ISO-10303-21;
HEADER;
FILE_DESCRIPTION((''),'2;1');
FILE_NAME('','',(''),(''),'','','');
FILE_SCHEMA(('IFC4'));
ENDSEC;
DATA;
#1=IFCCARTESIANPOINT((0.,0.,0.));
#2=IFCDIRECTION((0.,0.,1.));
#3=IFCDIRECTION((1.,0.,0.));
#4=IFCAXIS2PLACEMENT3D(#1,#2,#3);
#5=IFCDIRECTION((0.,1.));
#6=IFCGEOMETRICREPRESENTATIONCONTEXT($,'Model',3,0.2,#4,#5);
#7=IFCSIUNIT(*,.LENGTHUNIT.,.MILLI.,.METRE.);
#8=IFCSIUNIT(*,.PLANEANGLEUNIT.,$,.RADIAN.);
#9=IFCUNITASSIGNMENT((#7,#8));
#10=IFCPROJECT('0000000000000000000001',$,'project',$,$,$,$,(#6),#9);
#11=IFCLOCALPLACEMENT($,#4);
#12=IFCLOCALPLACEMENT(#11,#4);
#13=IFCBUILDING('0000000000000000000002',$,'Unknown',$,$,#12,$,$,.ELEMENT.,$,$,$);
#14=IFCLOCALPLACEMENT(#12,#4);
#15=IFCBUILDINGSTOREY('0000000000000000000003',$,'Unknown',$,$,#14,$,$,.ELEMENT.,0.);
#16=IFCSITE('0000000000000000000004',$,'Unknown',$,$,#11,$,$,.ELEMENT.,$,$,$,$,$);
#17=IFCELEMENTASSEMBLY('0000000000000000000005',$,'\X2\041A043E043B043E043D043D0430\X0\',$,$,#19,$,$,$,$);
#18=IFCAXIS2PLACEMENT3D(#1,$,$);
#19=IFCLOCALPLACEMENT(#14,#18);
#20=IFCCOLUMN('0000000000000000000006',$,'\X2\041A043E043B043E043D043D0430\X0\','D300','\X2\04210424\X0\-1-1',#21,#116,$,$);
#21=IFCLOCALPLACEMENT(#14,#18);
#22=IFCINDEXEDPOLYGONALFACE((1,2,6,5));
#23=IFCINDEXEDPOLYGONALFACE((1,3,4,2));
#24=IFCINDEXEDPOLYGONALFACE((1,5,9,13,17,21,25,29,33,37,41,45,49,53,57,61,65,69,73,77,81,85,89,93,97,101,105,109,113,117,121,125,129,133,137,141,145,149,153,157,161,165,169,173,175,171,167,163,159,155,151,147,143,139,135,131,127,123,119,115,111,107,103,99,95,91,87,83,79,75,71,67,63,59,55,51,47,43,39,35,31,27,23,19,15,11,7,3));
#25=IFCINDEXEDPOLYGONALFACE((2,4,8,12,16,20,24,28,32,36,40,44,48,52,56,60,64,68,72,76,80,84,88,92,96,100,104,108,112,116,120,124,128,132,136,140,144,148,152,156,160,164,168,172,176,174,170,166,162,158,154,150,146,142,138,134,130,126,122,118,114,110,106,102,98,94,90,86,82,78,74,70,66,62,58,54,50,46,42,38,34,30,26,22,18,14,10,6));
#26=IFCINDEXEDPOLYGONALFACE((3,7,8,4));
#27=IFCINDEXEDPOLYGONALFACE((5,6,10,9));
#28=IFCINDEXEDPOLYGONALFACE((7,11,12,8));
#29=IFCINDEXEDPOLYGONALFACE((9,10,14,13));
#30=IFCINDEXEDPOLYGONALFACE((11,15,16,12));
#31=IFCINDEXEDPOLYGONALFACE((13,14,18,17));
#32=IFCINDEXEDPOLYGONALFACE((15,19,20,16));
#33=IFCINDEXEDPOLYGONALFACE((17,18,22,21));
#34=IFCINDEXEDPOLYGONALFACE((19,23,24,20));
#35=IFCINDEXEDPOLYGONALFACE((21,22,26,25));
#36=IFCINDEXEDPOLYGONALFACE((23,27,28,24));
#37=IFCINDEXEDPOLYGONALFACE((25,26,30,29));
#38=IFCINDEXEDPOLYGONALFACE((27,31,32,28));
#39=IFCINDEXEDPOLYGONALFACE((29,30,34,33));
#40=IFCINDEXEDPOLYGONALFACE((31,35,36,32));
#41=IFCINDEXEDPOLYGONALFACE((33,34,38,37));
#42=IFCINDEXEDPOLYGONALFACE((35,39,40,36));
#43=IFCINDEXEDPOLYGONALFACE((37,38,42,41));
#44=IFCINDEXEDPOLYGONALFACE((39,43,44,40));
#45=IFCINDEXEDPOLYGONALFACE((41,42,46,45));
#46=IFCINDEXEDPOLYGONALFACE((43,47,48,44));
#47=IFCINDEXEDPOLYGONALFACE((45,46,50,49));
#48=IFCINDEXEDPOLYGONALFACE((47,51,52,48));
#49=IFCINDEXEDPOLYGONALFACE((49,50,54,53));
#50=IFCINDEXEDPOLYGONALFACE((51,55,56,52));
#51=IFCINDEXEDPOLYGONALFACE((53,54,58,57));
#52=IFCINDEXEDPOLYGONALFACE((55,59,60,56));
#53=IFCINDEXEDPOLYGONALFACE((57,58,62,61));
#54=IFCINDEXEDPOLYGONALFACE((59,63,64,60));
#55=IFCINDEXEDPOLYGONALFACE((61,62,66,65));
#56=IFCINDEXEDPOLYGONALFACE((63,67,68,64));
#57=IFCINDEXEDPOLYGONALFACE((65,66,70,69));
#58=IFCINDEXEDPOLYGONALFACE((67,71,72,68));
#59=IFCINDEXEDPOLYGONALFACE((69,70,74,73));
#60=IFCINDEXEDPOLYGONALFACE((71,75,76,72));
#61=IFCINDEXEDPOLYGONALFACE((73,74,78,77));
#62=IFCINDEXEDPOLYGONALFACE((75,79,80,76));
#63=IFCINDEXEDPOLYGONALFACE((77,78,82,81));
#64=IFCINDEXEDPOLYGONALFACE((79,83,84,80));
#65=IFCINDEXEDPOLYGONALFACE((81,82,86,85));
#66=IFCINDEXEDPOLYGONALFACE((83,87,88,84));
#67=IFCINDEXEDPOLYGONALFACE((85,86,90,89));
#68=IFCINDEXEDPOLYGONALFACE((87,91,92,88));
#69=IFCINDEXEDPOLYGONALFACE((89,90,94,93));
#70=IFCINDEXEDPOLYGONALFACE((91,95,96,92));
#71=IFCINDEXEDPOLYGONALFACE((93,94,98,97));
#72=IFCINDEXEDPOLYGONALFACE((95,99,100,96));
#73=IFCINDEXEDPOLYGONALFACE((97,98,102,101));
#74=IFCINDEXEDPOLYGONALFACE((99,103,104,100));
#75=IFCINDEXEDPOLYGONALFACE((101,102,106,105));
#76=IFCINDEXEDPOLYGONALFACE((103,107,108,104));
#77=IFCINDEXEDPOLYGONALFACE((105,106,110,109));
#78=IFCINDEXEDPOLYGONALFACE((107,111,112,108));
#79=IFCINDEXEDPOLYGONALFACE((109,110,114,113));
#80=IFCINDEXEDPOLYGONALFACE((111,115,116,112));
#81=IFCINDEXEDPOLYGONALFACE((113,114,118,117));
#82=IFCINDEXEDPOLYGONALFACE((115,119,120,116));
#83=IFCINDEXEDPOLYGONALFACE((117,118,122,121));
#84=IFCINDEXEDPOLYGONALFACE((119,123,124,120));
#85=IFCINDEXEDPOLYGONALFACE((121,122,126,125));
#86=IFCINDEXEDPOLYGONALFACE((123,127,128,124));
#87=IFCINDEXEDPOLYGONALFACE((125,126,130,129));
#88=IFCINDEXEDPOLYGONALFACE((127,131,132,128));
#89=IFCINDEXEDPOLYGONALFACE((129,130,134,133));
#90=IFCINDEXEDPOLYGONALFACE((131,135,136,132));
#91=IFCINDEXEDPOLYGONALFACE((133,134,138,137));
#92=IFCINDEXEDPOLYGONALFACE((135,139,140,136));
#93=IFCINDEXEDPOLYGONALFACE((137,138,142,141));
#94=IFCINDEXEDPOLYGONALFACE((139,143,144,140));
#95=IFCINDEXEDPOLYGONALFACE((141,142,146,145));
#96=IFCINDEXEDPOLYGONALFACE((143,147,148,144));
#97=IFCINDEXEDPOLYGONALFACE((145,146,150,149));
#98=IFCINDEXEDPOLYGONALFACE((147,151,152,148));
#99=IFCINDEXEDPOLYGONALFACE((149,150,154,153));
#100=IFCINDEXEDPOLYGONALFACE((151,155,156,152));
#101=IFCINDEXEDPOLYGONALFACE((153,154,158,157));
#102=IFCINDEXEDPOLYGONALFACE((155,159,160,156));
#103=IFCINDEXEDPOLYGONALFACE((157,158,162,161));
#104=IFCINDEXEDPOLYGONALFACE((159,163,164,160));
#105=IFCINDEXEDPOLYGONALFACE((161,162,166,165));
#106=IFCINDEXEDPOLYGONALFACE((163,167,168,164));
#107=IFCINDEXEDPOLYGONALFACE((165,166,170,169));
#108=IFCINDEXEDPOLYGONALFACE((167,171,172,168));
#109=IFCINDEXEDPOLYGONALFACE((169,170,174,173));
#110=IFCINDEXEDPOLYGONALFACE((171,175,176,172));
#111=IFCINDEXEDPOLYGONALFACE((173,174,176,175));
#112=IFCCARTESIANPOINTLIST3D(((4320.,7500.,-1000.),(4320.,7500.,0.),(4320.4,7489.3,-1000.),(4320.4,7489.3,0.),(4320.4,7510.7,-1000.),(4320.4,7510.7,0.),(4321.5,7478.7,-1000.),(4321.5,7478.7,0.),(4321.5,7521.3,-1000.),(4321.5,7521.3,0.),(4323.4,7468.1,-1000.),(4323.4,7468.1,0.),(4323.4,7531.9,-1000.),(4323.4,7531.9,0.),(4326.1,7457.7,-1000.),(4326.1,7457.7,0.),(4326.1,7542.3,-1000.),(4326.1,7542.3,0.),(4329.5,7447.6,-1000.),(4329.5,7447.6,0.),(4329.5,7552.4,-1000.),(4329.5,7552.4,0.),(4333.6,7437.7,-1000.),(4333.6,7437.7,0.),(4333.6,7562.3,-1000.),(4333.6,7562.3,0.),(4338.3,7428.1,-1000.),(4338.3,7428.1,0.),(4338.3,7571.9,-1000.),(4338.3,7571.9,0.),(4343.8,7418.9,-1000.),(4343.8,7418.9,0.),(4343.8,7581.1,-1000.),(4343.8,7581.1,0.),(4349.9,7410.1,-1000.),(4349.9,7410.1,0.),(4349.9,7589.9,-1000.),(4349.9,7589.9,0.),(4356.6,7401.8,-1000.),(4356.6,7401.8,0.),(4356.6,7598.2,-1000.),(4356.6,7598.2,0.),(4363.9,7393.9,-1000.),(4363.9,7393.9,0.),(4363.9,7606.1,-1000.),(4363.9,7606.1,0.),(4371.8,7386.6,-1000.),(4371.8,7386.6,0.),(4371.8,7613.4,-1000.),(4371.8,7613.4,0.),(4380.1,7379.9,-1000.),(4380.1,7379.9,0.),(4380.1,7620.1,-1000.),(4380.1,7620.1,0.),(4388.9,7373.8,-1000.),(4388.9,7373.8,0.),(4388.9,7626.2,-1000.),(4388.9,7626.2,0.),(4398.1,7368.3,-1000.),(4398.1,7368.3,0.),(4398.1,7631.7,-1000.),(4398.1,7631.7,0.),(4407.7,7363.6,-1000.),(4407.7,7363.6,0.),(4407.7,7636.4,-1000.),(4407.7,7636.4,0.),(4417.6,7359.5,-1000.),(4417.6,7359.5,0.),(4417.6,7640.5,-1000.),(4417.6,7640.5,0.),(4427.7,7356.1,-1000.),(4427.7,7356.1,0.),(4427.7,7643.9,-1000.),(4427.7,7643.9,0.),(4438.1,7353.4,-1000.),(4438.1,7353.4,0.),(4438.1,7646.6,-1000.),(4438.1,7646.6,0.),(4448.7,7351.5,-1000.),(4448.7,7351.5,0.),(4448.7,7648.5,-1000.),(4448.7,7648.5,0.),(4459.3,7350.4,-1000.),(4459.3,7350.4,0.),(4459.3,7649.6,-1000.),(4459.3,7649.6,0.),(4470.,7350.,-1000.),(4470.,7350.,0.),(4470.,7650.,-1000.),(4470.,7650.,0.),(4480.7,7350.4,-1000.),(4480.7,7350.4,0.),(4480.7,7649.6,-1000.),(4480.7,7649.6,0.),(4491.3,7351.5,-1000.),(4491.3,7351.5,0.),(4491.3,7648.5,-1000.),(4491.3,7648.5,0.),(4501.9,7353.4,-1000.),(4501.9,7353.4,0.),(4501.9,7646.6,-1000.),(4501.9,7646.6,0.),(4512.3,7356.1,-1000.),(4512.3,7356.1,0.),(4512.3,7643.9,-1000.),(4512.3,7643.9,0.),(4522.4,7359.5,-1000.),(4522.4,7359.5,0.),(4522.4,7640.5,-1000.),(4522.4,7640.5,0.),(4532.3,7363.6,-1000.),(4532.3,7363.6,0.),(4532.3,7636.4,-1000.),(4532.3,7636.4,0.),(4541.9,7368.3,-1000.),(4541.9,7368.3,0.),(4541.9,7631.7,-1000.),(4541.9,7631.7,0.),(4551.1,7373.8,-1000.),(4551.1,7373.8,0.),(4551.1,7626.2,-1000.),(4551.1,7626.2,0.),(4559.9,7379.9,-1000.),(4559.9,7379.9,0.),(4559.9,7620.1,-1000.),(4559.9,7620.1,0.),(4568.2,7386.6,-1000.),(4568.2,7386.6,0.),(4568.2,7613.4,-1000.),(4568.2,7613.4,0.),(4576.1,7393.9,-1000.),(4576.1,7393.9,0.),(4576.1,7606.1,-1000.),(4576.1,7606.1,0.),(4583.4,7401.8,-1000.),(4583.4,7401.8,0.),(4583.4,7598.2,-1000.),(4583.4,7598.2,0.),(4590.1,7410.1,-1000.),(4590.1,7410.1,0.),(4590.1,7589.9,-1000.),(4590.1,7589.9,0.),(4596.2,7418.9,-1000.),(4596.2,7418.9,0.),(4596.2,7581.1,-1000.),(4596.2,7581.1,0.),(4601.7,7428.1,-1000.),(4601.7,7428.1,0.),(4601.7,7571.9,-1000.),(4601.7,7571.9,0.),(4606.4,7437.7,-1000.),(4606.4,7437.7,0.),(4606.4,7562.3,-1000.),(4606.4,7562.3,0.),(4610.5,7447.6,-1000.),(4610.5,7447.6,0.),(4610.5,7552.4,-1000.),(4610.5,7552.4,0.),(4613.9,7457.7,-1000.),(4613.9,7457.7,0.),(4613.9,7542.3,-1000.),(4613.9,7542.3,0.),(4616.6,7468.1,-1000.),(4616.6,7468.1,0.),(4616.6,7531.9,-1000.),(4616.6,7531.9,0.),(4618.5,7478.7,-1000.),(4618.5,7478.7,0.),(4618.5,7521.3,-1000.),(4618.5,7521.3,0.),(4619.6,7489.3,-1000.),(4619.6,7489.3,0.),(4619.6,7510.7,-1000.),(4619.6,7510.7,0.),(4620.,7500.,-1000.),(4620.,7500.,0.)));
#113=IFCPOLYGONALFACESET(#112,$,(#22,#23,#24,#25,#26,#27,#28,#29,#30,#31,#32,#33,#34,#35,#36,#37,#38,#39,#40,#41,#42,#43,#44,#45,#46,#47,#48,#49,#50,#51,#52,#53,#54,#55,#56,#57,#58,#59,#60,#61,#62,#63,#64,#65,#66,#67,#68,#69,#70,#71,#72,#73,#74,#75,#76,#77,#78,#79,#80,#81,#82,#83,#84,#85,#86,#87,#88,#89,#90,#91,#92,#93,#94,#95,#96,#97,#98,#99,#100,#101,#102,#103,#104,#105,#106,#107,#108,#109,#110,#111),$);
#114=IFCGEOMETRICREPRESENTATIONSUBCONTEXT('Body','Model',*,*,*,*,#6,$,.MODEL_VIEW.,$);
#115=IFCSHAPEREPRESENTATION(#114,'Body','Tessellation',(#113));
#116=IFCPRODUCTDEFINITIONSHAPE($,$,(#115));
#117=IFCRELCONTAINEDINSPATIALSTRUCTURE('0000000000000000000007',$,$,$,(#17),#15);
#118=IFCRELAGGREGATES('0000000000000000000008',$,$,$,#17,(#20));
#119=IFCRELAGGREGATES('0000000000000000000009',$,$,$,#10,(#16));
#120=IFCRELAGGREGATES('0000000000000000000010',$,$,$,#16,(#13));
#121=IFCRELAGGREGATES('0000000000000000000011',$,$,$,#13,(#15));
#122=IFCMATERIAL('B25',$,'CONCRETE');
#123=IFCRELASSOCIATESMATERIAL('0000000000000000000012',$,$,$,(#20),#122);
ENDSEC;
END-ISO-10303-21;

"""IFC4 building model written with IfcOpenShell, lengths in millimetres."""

from ifc_helpers import new_model, si_unit, direction, frame, origin_with_axes, place, context, subcontext, project, spatial, line, indexed_curve, outline, extrude, material, element, aggregate, save


model = new_model("IFC4")

# Units and contexts
model_context = context("Model", 3, precision=0.2, world=origin_with_axes(), true_north=direction((0.0, 1.0)))
body_context = subcontext(model_context, "Body", "Model", "MODEL_VIEW")
ifc_project = project(units=[si_unit("LENGTHUNIT", "METRE", prefix="MILLI"), si_unit("PLANEANGLEUNIT", "RADIAN")], contexts=[model_context])

# Site, building, storey
site_placement = place(None, origin_with_axes())
site = spatial("IfcSite", under=ifc_project, at=site_placement, Name="Unknown", CompositionType="ELEMENT")
building_placement = place(site_placement, origin_with_axes())
building = spatial("IfcBuilding", under=site, at=building_placement, Name="Unknown", CompositionType="ELEMENT")
storey_placement = place(building_placement, origin_with_axes())
storey = spatial("IfcBuildingStorey", under=building, at=storey_placement, Name="Unknown", CompositionType="ELEMENT", Elevation=0.0)

# Shared definitions
placement_1 = place(storey_placement, frame((4470.0, 7500.0, -1000.0), z_axis=(-1.0, 0.0, 0.0), x_axis=(0.0, 0.0, 1.0)))
placement_2 = place(placement_1, origin_with_axes())

# Element assembly, column
ifc_material_1 = material(Name="B25", Category="CONCRETE")
assembly_1 = element("IfcElementAssembly", 1, at=placement_1, inside=storey, Name="Колонна")
column_1 = element("IfcColumn", 2, at=placement_2, material=ifc_material_1, Name="Колонна", Description="D300", ObjectType="СФ-1-1", context=body_context, shape_type="SolidModel", body=[
    extrude(outline(indexed_curve([(150.0, 0.0), (149.6, 10.7), (148.5, 21.3), (146.6, 31.9), (143.9, 42.3), (140.5, 52.4), (136.4, 62.3), (131.7, 71.9), (126.2, 81.1), (120.1, 89.9), (113.4, 98.2), (106.1, 106.1), (98.2, 113.4), (89.9, 120.1), (81.1, 126.2), (71.9, 131.7), (62.3, 136.4), (52.4, 140.5), (42.3, 143.9), (31.9, 146.6), (21.3, 148.5), (10.7, 149.6), (0.0, 150.0), (-10.7, 149.6), (-21.3, 148.5), (-31.9, 146.6), (-42.3, 143.9), (-52.4, 140.5), (-62.3, 136.4), (-71.9, 131.7), (-81.1, 126.2), (-89.9, 120.1), (-98.2, 113.4), (-106.1, 106.1), (-113.4, 98.2), (-120.1, 89.9), (-126.2, 81.1), (-131.7, 71.9), (-136.4, 62.3), (-140.5, 52.4), (-143.9, 42.3), (-146.6, 31.9), (-148.5, 21.3), (-149.6, 10.7), (-150.0, 0.0), (-149.6, -10.7), (-148.5, -21.3), (-146.6, -31.9), (-143.9, -42.3), (-140.5, -52.4), (-136.4, -62.3), (-131.7, -71.9), (-126.2, -81.1), (-120.1, -89.9), (-113.4, -98.2), (-106.1, -106.1), (-98.2, -113.4), (-89.9, -120.1), (-81.1, -126.2), (-71.9, -131.7), (-62.3, -136.4), (-52.4, -140.5), (-42.3, -143.9), (-31.9, -146.6), (-21.3, -148.5), (-10.7, -149.6), (0.0, -150.0), (10.7, -149.6), (21.3, -148.5), (31.9, -146.6), (42.3, -143.9), (52.4, -140.5), (62.3, -136.4), (71.9, -131.7), (81.1, -126.2), (89.9, -120.1), (98.2, -113.4), (106.1, -106.1), (113.4, -98.2), (120.1, -89.9), (126.2, -81.1), (131.7, -71.9), (136.4, -62.3), (140.5, -52.4), (143.9, -42.3), (146.6, -31.9), (148.5, -21.3), (149.6, -10.7)], segments=[line(1, 2, 3, 4, 5, 6, 7, 8, 9, 10, 11, 12, 13, 14, 15, 16, 17, 18, 19, 20, 21, 22, 23, 24, 25, 26, 27, 28, 29, 30, 31, 32, 33, 34, 35, 36, 37, 38, 39, 40, 41, 42, 43, 44, 45, 46, 47, 48, 49, 50, 51, 52, 53, 54, 55, 56, 57, 58, 59, 60, 61, 62, 63, 64, 65, 66, 67, 68, 69, 70, 71, 72, 73, 74, 75, 76, 77, 78, 79, 80, 81, 82, 83, 84, 85, 86, 87, 88, 1)])), frame((0.0, 0.0, 0.0), z_axis=(-1.0, 0.0, 0.0), x_axis=(0.0, 0.0, 1.0)), (0.0, 0.0, -1.0), 1000.0),
])
aggregate(assembly_1, [column_1])

save(model, "model.ifc")
